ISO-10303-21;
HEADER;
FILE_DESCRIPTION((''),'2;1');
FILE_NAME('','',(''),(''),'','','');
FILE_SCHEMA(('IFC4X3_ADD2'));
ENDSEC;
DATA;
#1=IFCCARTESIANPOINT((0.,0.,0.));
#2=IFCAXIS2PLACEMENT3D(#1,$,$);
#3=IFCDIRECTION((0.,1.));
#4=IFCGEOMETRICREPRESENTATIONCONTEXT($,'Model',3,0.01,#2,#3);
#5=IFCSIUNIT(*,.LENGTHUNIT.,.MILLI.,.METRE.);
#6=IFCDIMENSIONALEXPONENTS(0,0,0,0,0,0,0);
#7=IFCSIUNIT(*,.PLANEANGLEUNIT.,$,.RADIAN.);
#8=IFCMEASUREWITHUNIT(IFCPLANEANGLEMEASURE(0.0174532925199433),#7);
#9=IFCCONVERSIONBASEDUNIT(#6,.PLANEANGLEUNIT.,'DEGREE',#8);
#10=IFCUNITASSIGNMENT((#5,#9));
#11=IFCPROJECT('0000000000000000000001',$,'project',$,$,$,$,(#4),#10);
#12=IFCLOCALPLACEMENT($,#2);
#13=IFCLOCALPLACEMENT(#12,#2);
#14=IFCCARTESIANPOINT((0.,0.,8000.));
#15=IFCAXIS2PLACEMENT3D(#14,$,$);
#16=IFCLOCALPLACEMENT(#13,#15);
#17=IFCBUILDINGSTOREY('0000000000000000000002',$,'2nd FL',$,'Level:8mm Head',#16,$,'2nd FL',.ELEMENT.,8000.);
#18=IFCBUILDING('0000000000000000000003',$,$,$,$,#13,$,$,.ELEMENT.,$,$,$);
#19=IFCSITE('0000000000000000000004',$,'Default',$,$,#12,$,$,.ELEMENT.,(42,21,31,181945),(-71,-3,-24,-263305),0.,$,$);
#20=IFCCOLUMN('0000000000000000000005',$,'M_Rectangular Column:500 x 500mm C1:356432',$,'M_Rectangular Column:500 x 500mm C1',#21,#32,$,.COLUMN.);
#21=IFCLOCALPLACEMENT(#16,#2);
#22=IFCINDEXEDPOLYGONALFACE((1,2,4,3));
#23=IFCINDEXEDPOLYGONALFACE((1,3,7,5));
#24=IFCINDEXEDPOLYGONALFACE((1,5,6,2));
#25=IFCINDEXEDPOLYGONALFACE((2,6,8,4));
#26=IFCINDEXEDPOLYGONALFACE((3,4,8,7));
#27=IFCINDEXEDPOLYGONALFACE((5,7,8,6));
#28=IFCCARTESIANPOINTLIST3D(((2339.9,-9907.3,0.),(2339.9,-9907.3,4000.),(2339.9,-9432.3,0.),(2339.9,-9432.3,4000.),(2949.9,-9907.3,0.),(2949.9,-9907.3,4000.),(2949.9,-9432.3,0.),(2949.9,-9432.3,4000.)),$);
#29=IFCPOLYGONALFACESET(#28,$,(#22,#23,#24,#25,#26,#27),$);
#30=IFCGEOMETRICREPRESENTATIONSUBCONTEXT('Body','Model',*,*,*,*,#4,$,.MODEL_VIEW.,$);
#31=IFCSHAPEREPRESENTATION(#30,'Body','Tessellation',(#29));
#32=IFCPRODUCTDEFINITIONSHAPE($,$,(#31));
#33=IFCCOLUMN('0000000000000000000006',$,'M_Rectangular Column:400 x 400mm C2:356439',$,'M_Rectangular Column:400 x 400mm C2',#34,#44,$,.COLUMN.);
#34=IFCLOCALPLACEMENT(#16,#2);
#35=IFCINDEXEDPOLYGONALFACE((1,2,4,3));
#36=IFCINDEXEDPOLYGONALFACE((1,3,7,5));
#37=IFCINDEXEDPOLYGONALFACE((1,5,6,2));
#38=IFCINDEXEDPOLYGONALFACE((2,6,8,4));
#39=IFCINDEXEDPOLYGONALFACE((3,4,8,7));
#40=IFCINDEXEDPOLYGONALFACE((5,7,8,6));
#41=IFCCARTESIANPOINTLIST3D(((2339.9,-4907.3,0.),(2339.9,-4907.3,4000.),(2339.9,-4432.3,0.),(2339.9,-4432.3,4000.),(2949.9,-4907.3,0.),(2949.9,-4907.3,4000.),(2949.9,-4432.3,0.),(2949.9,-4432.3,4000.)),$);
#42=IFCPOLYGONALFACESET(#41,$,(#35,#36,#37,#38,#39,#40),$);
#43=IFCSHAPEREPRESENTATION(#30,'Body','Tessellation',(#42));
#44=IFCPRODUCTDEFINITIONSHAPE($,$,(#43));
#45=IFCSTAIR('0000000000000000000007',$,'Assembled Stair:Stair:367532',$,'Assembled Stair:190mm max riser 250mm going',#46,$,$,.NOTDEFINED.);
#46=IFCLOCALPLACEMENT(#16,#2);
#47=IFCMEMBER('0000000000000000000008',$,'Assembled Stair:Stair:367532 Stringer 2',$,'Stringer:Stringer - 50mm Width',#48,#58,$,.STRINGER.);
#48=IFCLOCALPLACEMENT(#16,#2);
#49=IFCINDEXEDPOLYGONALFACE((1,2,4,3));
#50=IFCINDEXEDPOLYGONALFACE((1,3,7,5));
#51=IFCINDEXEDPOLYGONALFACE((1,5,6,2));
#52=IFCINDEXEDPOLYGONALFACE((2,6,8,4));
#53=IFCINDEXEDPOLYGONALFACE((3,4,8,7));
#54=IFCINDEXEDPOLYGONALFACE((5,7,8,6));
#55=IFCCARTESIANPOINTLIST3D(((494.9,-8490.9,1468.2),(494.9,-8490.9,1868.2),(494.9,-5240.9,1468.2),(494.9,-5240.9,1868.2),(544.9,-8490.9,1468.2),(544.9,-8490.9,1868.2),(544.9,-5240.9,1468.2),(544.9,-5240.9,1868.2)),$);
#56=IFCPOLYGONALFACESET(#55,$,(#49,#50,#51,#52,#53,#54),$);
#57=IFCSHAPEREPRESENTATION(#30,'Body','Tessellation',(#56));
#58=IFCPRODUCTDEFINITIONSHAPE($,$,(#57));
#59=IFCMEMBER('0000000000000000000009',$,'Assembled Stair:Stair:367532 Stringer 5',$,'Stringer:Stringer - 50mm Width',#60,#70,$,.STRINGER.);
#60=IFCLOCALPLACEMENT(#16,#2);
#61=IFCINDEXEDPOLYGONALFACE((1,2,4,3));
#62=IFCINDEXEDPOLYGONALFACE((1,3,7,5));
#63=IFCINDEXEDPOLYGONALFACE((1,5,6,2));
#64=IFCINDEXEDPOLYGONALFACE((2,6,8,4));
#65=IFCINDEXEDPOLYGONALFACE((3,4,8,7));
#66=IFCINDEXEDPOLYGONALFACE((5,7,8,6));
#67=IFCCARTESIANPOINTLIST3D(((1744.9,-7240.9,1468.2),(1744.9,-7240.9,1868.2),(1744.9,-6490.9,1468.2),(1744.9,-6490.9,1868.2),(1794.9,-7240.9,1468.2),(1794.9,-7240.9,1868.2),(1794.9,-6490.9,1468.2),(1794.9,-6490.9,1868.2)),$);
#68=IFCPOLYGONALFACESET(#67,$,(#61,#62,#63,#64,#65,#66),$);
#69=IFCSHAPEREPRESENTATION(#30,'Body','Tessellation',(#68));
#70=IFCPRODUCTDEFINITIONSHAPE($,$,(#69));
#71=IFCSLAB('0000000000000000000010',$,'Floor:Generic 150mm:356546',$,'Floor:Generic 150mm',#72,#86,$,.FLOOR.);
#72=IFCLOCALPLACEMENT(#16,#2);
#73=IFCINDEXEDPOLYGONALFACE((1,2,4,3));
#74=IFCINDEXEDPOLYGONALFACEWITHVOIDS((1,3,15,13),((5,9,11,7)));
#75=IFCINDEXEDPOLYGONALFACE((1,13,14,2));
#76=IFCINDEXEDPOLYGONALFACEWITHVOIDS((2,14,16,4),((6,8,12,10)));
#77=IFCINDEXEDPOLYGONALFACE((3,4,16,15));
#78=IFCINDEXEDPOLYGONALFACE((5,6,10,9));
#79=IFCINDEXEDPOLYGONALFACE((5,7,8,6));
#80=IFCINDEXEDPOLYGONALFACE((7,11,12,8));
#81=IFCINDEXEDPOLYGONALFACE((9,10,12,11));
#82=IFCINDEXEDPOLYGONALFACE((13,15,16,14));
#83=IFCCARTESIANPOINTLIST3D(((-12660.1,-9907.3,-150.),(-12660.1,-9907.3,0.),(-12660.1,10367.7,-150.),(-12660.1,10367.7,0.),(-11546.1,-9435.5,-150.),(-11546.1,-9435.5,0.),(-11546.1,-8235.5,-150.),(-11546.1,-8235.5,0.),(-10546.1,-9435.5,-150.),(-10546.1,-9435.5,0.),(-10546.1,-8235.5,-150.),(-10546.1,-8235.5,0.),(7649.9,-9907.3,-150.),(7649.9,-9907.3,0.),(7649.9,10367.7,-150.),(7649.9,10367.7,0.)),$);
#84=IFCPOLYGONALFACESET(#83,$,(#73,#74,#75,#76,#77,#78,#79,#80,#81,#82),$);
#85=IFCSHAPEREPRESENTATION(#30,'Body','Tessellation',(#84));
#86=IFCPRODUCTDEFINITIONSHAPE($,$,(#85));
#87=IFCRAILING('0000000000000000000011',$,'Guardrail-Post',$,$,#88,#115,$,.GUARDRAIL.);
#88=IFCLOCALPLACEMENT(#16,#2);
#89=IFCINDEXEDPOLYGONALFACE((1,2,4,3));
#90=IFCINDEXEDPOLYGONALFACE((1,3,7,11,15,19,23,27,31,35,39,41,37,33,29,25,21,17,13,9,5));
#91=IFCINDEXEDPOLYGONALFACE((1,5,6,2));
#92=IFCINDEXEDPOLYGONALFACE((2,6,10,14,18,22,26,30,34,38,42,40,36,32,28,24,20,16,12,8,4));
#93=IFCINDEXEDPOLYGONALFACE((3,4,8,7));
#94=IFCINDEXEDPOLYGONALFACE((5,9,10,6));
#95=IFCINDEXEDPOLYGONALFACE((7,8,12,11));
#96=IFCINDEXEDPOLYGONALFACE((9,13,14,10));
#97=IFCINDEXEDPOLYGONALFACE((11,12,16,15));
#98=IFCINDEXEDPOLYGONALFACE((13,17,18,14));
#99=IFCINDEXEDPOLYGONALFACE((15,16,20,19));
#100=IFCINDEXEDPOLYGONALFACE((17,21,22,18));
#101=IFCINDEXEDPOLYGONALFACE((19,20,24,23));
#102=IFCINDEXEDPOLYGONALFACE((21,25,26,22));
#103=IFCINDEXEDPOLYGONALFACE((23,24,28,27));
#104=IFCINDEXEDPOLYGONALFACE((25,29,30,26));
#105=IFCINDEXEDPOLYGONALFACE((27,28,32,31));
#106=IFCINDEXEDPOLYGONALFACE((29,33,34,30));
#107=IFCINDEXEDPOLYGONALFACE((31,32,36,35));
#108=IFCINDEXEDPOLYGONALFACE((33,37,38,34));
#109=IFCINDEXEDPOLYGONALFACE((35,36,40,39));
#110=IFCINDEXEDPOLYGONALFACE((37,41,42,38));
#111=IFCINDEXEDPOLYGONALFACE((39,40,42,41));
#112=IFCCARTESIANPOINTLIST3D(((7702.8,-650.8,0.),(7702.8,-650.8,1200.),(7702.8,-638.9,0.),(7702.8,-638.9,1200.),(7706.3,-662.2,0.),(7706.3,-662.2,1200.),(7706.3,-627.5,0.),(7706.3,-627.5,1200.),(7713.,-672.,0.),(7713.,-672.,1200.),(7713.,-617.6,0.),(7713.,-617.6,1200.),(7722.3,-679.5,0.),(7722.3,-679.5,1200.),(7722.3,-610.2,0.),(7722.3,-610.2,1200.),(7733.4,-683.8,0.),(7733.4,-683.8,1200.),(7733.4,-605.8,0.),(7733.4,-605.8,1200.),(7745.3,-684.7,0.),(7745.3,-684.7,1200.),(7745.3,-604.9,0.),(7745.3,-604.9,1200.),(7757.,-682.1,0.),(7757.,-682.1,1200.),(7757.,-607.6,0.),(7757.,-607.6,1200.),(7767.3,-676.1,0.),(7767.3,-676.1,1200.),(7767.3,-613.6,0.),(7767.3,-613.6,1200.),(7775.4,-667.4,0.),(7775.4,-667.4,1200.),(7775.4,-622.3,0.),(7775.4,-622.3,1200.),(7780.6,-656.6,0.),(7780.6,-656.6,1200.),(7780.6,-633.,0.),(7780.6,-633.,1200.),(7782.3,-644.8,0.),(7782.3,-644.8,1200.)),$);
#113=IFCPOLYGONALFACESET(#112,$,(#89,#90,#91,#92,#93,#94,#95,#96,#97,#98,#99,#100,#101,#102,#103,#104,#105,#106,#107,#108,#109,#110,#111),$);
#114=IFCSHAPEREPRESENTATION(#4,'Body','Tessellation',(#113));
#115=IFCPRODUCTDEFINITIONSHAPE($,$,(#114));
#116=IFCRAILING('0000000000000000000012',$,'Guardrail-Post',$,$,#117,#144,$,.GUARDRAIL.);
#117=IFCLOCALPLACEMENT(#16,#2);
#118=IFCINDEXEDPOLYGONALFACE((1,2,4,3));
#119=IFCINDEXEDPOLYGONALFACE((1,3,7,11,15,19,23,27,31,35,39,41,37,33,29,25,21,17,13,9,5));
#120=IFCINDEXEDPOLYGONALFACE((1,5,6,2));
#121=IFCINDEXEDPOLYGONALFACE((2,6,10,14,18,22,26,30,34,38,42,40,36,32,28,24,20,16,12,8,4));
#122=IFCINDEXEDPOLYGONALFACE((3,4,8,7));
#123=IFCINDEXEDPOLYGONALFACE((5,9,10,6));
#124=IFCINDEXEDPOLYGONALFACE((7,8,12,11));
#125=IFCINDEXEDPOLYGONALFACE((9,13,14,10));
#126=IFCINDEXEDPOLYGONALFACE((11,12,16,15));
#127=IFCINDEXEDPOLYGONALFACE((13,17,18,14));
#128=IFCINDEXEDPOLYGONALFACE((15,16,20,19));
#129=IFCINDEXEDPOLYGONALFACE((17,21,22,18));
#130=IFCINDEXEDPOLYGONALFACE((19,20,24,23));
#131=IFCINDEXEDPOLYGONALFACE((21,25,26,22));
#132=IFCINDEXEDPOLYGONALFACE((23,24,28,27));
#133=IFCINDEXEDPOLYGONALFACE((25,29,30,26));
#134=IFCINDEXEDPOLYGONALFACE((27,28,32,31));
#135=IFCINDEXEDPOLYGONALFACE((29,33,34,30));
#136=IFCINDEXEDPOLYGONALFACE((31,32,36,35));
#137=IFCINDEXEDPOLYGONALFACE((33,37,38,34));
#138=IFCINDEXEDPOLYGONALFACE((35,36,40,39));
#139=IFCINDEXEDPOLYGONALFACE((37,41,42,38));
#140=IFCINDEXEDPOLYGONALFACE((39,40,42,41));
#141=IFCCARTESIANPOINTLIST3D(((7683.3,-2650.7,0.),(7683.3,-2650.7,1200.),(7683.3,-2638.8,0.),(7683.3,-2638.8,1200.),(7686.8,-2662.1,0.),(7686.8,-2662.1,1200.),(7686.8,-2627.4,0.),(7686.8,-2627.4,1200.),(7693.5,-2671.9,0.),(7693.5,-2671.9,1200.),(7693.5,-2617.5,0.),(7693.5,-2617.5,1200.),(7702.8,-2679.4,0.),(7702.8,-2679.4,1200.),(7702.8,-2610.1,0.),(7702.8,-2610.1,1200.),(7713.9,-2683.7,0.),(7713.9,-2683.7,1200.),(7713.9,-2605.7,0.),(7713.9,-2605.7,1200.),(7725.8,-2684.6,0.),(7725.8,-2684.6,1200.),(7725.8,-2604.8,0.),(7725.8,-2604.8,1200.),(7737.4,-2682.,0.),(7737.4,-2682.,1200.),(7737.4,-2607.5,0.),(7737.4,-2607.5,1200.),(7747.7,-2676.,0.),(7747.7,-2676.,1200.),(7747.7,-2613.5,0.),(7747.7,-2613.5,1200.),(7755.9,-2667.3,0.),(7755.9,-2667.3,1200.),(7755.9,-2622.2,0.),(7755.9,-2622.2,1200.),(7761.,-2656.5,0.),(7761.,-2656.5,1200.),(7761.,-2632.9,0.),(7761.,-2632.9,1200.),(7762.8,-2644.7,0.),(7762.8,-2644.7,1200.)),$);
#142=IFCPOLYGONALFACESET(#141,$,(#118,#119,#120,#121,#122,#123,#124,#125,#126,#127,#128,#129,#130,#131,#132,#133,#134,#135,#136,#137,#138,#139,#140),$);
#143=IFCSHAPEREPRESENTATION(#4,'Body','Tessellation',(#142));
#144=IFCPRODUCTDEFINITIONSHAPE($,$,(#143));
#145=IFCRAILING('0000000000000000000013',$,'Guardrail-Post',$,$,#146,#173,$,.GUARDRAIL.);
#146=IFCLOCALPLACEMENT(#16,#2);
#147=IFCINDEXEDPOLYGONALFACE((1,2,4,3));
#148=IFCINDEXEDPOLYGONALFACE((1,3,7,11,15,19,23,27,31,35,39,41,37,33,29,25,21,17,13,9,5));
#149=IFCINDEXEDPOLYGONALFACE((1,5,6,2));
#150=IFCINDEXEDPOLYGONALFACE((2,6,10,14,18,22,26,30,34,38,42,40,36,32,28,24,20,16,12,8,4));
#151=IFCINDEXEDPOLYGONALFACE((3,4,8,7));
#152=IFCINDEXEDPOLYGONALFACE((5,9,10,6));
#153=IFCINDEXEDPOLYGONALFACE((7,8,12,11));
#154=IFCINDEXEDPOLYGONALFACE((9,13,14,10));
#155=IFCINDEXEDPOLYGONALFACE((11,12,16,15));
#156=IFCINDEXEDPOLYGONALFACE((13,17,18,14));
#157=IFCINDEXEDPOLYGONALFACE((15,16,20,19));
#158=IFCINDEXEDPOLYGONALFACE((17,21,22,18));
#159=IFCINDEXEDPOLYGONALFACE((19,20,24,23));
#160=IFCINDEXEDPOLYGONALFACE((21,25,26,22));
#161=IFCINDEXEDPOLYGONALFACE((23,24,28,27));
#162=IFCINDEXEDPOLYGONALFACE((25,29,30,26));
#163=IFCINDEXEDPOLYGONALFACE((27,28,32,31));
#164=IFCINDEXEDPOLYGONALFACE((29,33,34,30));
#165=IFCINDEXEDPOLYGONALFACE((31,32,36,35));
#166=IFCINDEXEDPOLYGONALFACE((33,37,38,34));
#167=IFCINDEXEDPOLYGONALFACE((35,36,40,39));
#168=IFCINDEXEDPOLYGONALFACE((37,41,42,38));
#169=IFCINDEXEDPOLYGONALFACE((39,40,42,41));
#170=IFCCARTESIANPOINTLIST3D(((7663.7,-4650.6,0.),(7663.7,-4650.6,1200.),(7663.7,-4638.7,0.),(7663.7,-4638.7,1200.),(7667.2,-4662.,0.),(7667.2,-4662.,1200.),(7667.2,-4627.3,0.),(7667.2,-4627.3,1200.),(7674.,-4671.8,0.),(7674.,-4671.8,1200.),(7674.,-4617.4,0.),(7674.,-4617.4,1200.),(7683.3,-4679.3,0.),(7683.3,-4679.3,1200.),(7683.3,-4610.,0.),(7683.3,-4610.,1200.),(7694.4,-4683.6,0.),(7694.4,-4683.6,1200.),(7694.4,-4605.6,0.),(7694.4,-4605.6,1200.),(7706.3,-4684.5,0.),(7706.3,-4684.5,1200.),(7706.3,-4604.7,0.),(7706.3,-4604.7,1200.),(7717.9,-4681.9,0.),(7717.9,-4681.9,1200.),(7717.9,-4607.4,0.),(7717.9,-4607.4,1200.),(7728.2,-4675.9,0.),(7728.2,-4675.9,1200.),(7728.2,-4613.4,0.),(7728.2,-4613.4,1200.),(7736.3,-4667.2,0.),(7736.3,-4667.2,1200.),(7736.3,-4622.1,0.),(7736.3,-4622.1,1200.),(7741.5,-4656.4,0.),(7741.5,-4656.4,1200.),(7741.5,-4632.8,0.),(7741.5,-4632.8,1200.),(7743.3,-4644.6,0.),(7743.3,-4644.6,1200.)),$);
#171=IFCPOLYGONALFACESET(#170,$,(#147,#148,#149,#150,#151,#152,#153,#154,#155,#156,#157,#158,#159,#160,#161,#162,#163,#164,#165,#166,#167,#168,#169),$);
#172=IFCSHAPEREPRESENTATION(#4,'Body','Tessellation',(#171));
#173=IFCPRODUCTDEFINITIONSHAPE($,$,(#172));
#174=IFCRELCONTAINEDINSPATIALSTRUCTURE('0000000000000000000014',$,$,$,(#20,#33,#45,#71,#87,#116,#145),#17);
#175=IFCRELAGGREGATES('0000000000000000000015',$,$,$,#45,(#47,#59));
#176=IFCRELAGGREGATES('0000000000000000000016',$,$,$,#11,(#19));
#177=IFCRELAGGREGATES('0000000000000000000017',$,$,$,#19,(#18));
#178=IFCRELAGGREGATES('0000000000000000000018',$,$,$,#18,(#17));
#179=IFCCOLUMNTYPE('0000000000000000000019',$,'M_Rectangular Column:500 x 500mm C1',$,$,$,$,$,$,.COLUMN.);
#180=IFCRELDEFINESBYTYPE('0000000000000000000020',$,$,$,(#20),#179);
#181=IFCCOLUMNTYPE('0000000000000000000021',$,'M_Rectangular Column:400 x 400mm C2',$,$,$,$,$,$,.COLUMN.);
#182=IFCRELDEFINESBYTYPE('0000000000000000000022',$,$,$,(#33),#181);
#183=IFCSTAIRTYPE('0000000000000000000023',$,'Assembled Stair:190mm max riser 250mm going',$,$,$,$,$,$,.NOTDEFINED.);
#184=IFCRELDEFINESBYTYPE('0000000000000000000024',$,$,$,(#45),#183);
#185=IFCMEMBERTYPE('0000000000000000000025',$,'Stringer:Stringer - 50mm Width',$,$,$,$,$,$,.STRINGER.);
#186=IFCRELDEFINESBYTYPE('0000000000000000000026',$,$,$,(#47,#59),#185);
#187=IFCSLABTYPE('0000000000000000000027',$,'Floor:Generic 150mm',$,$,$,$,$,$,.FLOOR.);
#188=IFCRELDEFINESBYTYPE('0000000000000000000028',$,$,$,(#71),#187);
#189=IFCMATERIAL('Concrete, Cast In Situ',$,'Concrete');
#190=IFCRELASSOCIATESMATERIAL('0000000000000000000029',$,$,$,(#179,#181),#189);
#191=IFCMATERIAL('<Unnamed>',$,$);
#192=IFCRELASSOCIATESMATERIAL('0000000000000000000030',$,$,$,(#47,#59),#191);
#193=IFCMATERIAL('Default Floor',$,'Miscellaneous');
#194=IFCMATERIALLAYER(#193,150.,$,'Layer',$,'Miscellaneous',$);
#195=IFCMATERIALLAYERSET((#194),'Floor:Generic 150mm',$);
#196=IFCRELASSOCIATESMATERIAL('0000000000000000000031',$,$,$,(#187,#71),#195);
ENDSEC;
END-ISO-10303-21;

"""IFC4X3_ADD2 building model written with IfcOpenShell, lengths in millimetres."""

from ifc_helpers import new_model, entity, si_unit, converted_unit, direction, frame, frame_2d, origin, origin_with_axes, origin_2d, origin_2d_with_axis, place, context, subcontext, project, spatial, rectangle, circle, extrude, boolean, source, transform, mapped, material, layer, layer_set, layer_usage, material_profile, profile_set, type_object, type_shapes, element, aggregate, save


model = new_model("IFC4X3_ADD2")

# Units and contexts
model_context = context("Model", 3, precision=0.01, world=origin(), true_north=direction((0.0, 1.0)))
body_context = subcontext(model_context, "Body", "Model", "MODEL_VIEW")
ifc_project = project(units=[si_unit("LENGTHUNIT", "METRE", prefix="MILLI"), converted_unit("PLANEANGLEUNIT", "DEGREE", entity("IfcPlaneAngleMeasure", 0.0174532925199433), si_unit("PLANEANGLEUNIT", "RADIAN"), dimensions=[0, 0, 0, 0, 0, 0, 0])], contexts=[model_context])

# Site, building, storey
site_placement = place(None, origin())
site = spatial("IfcSite", under=ifc_project, at=site_placement, Name="Default", CompositionType="ELEMENT", RefLatitude=(42, 21, 31, 181945), RefLongitude=(-71, -3, -24, -263305), RefElevation=0.0)
building_placement = place(site_placement, origin())
building = spatial("IfcBuilding", under=site, at=building_placement, CompositionType="ELEMENT")
storey_placement = place(building_placement, frame((0.0, 0.0, 8000.0)))
storey = spatial("IfcBuildingStorey", under=building, at=storey_placement, Name="2nd FL", ObjectType="Level:8mm Head", LongName="2nd FL", CompositionType="ELEMENT", Elevation=8000.0)

# Columns
ifc_material_1 = material(Name="Concrete, Cast In Situ", Category="Concrete")
ifc_material_profile_1 = material_profile(ifc_material_1, rectangle(XDim=610.0, YDim=475.0, at=frame_2d((0.0, 0.0), x_axis=(1.0, 0.0))), Name="500 x 500mm C1")
ifc_profile_set_1 = profile_set([ifc_material_profile_1], Name="500 x 500mm C1")
column_type_1 = type_object("IfcColumnType", Name="M_Rectangular Column:500 x 500mm C1", PredefinedType="COLUMN", material=ifc_profile_set_1)
shared_shape_1 = source(origin(), body_context, "Body", "SweptSolid", [
    extrude(rectangle(XDim=610.0, YDim=475.0, at=origin_2d_with_axis()), frame((0.0, 0.0, 8000.0), z_axis=(0.0, 0.0, 1.0), x_axis=(-1.0, 0.0, 0.0)), (0.0, 0.0, 1.0), 4000.0),
])
type_shapes(column_type_1, [shared_shape_1])
column_1_placement = place(storey_placement, frame((2644.9, -9669.8, -8000.0)))
element("IfcColumn", 1, at=column_1_placement, inside=storey, type_object=column_type_1, Name="M_Rectangular Column:500 x 500mm C1:356432", ObjectType="M_Rectangular Column:500 x 500mm C1", PredefinedType="COLUMN", context=body_context, shape_type="MappedRepresentation", body=[
    mapped(shared_shape_1, transform((0.0, 0.0, 0.0), scale=1.0)),
])
ifc_material_profile_2 = material_profile(ifc_material_1, rectangle(XDim=610.0, YDim=475.0, at=origin_2d_with_axis()), Name="400 x 400mm C2")
ifc_profile_set_2 = profile_set([ifc_material_profile_2], Name="400 x 400mm C2")
column_type_2 = type_object("IfcColumnType", Name="M_Rectangular Column:400 x 400mm C2", PredefinedType="COLUMN", material=ifc_profile_set_2)
shared_shape_2 = source(origin(), body_context, "Body", "SweptSolid", [
    extrude(rectangle(XDim=610.0, YDim=475.0, at=origin_2d_with_axis()), frame((0.0, 0.0, 8000.0), z_axis=(0.0, 0.0, 1.0), x_axis=(-1.0, 0.0, 0.0)), (0.0, 0.0, 1.0), 4000.0),
])
type_shapes(column_type_2, [shared_shape_2])
column_2_placement = place(storey_placement, frame((2644.9, -4669.8, -8000.0)))
element("IfcColumn", 2, at=column_2_placement, inside=storey, type_object=column_type_2, Name="M_Rectangular Column:400 x 400mm C2:356439", ObjectType="M_Rectangular Column:400 x 400mm C2", PredefinedType="COLUMN", context=body_context, shape_type="MappedRepresentation", body=[
    mapped(shared_shape_2, transform((0.0, 0.0, 0.0), scale=1.0)),
])

# Stair, members
stair_type = type_object("IfcStairType", Name="Assembled Stair:190mm max riser 250mm going", PredefinedType="NOTDEFINED")
stair_placement = place(storey_placement, origin())
stair = element("IfcStair", 3, at=stair_placement, inside=storey, type_object=stair_type, Name="Assembled Stair:Stair:367532", ObjectType="Assembled Stair:190mm max riser 250mm going", PredefinedType="NOTDEFINED")
ifc_material_2 = material(Name="<Unnamed>")
member_type = type_object("IfcMemberType", Name="Stringer:Stringer - 50mm Width", PredefinedType="STRINGER")
member_1_placement = place(stair_placement, frame((494.9, -8490.9, 1468.2)))
member_1 = element("IfcMember", 4, at=member_1_placement, type_object=member_type, material=ifc_material_2, Name="Assembled Stair:Stair:367532 Stringer 2", ObjectType="Stringer:Stringer - 50mm Width", PredefinedType="STRINGER", context=body_context, shape_type="SweptSolid", body=[
    extrude(rectangle(XDim=3250.0, YDim=50.0, at=origin_2d_with_axis()), frame((25.0, 1625.0, 0.0), z_axis=(0.0, 0.0, 1.0), x_axis=(0.0, 1.0, 0.0)), (0.0, 0.0, 1.0), 400.0),
])
member_2_placement = place(stair_placement, frame((1744.9, -7240.9, 1468.2)))
member_2 = element("IfcMember", 5, at=member_2_placement, type_object=member_type, material=ifc_material_2, Name="Assembled Stair:Stair:367532 Stringer 5", ObjectType="Stringer:Stringer - 50mm Width", PredefinedType="STRINGER", context=body_context, shape_type="SweptSolid", body=[
    extrude(rectangle(XDim=750.0, YDim=50.0, at=frame_2d((0.0, 0.0), x_axis=(1.0, 0.0))), frame((25.0, 375.0, 0.0), z_axis=(0.0, 0.0, 1.0), x_axis=(0.0, 1.0, 0.0)), (0.0, 0.0, 1.0), 400.0),
])

# Slab, opening
ifc_material_3 = material(Name="Default Floor", Category="Miscellaneous")
ifc_layer = layer(ifc_material_3, 150.0, Name="Layer", Category="Miscellaneous")
ifc_layer_set = layer_set([ifc_layer], Name="Floor:Generic 150mm")
ifc_layer_usage = layer_usage(ifc_layer_set, "AXIS3", "POSITIVE", 0.0)
slab_type = type_object("IfcSlabType", Name="Floor:Generic 150mm", PredefinedType="FLOOR", material=ifc_layer_set)
slab_placement = place(storey_placement, origin())
slab = element("IfcSlab", 6, at=slab_placement, inside=storey, type_object=slab_type, material=ifc_layer_usage, Name="Floor:Generic 150mm:356546", ObjectType="Floor:Generic 150mm", PredefinedType="FLOOR", context=body_context, shape_type="SweptSolid", body=[
    boolean("DIFFERENCE", extrude(rectangle(XDim=20275.0, YDim=20310.0, at=origin_2d_with_axis()), frame((-2505.1, 230.2, 0.0), z_axis=(0.0, 0.0, -1.0), x_axis=(0.0, 1.0, 0.0)), (0.0, 0.0, 1.0), 150.0), extrude(rectangle(XDim=1200.0, YDim=1000.0, at=frame_2d((0.0, 0.0), x_axis=(1.0, 0.0))), frame((-11046.1, -8835.5, 0.0), z_axis=(0.0, 0.0, -1.0), x_axis=(0.0, -1.0, 0.0)), (0.0, 0.0, 1.0), 150.0)),
])
opening_placement = place(slab_placement, origin())
element("IfcOpeningElement", 7, at=opening_placement, cuts=slab, PredefinedType="OPENING", context=body_context, shape_type="SweptSolid", body=[
    extrude(rectangle(XDim=1200.0, YDim=1000.0, at=frame_2d((0.0, 0.0), x_axis=(1.0, 0.0))), frame((-11046.1, -8835.5, -150.0), z_axis=(0.0, 0.0, 1.0), x_axis=(0.0, 1.0, 0.0)), (0.0, 0.0, 1.0), 150.0),
])

aggregate(stair, [member_1, member_2])

# Railings
for number, where, z_axis, x_axis, name in (
    (8, (7742.3, -644.8, 8000.0), (0.0, 0.0, 1.0), (1.0, 0.0, 0.0), "Guardrail-Post"),
    (9, (7722.8, -2644.7, 8000.0), (0.0, 0.0, 1.0), (1.0, 0.0, 0.0), "Guardrail-Post"),
    (10, (7703.3, -4644.6, 8000.0), (0.0, 0.0, 1.0), (1.0, 0.0, 0.0), "Guardrail-Post"),
):
    element("IfcRailing", number, at=place(None, frame(where, z_axis=z_axis, x_axis=x_axis)), inside=storey, Name=name, PredefinedType="GUARDRAIL", context=model_context, shape_type="SweptSolid", body=[
        extrude(circle(Radius=40.0, at=origin_2d()), origin_with_axes(), (0.0, 0.0, 1.0), 1200.0),
    ])

save(model, "model.ifc")
